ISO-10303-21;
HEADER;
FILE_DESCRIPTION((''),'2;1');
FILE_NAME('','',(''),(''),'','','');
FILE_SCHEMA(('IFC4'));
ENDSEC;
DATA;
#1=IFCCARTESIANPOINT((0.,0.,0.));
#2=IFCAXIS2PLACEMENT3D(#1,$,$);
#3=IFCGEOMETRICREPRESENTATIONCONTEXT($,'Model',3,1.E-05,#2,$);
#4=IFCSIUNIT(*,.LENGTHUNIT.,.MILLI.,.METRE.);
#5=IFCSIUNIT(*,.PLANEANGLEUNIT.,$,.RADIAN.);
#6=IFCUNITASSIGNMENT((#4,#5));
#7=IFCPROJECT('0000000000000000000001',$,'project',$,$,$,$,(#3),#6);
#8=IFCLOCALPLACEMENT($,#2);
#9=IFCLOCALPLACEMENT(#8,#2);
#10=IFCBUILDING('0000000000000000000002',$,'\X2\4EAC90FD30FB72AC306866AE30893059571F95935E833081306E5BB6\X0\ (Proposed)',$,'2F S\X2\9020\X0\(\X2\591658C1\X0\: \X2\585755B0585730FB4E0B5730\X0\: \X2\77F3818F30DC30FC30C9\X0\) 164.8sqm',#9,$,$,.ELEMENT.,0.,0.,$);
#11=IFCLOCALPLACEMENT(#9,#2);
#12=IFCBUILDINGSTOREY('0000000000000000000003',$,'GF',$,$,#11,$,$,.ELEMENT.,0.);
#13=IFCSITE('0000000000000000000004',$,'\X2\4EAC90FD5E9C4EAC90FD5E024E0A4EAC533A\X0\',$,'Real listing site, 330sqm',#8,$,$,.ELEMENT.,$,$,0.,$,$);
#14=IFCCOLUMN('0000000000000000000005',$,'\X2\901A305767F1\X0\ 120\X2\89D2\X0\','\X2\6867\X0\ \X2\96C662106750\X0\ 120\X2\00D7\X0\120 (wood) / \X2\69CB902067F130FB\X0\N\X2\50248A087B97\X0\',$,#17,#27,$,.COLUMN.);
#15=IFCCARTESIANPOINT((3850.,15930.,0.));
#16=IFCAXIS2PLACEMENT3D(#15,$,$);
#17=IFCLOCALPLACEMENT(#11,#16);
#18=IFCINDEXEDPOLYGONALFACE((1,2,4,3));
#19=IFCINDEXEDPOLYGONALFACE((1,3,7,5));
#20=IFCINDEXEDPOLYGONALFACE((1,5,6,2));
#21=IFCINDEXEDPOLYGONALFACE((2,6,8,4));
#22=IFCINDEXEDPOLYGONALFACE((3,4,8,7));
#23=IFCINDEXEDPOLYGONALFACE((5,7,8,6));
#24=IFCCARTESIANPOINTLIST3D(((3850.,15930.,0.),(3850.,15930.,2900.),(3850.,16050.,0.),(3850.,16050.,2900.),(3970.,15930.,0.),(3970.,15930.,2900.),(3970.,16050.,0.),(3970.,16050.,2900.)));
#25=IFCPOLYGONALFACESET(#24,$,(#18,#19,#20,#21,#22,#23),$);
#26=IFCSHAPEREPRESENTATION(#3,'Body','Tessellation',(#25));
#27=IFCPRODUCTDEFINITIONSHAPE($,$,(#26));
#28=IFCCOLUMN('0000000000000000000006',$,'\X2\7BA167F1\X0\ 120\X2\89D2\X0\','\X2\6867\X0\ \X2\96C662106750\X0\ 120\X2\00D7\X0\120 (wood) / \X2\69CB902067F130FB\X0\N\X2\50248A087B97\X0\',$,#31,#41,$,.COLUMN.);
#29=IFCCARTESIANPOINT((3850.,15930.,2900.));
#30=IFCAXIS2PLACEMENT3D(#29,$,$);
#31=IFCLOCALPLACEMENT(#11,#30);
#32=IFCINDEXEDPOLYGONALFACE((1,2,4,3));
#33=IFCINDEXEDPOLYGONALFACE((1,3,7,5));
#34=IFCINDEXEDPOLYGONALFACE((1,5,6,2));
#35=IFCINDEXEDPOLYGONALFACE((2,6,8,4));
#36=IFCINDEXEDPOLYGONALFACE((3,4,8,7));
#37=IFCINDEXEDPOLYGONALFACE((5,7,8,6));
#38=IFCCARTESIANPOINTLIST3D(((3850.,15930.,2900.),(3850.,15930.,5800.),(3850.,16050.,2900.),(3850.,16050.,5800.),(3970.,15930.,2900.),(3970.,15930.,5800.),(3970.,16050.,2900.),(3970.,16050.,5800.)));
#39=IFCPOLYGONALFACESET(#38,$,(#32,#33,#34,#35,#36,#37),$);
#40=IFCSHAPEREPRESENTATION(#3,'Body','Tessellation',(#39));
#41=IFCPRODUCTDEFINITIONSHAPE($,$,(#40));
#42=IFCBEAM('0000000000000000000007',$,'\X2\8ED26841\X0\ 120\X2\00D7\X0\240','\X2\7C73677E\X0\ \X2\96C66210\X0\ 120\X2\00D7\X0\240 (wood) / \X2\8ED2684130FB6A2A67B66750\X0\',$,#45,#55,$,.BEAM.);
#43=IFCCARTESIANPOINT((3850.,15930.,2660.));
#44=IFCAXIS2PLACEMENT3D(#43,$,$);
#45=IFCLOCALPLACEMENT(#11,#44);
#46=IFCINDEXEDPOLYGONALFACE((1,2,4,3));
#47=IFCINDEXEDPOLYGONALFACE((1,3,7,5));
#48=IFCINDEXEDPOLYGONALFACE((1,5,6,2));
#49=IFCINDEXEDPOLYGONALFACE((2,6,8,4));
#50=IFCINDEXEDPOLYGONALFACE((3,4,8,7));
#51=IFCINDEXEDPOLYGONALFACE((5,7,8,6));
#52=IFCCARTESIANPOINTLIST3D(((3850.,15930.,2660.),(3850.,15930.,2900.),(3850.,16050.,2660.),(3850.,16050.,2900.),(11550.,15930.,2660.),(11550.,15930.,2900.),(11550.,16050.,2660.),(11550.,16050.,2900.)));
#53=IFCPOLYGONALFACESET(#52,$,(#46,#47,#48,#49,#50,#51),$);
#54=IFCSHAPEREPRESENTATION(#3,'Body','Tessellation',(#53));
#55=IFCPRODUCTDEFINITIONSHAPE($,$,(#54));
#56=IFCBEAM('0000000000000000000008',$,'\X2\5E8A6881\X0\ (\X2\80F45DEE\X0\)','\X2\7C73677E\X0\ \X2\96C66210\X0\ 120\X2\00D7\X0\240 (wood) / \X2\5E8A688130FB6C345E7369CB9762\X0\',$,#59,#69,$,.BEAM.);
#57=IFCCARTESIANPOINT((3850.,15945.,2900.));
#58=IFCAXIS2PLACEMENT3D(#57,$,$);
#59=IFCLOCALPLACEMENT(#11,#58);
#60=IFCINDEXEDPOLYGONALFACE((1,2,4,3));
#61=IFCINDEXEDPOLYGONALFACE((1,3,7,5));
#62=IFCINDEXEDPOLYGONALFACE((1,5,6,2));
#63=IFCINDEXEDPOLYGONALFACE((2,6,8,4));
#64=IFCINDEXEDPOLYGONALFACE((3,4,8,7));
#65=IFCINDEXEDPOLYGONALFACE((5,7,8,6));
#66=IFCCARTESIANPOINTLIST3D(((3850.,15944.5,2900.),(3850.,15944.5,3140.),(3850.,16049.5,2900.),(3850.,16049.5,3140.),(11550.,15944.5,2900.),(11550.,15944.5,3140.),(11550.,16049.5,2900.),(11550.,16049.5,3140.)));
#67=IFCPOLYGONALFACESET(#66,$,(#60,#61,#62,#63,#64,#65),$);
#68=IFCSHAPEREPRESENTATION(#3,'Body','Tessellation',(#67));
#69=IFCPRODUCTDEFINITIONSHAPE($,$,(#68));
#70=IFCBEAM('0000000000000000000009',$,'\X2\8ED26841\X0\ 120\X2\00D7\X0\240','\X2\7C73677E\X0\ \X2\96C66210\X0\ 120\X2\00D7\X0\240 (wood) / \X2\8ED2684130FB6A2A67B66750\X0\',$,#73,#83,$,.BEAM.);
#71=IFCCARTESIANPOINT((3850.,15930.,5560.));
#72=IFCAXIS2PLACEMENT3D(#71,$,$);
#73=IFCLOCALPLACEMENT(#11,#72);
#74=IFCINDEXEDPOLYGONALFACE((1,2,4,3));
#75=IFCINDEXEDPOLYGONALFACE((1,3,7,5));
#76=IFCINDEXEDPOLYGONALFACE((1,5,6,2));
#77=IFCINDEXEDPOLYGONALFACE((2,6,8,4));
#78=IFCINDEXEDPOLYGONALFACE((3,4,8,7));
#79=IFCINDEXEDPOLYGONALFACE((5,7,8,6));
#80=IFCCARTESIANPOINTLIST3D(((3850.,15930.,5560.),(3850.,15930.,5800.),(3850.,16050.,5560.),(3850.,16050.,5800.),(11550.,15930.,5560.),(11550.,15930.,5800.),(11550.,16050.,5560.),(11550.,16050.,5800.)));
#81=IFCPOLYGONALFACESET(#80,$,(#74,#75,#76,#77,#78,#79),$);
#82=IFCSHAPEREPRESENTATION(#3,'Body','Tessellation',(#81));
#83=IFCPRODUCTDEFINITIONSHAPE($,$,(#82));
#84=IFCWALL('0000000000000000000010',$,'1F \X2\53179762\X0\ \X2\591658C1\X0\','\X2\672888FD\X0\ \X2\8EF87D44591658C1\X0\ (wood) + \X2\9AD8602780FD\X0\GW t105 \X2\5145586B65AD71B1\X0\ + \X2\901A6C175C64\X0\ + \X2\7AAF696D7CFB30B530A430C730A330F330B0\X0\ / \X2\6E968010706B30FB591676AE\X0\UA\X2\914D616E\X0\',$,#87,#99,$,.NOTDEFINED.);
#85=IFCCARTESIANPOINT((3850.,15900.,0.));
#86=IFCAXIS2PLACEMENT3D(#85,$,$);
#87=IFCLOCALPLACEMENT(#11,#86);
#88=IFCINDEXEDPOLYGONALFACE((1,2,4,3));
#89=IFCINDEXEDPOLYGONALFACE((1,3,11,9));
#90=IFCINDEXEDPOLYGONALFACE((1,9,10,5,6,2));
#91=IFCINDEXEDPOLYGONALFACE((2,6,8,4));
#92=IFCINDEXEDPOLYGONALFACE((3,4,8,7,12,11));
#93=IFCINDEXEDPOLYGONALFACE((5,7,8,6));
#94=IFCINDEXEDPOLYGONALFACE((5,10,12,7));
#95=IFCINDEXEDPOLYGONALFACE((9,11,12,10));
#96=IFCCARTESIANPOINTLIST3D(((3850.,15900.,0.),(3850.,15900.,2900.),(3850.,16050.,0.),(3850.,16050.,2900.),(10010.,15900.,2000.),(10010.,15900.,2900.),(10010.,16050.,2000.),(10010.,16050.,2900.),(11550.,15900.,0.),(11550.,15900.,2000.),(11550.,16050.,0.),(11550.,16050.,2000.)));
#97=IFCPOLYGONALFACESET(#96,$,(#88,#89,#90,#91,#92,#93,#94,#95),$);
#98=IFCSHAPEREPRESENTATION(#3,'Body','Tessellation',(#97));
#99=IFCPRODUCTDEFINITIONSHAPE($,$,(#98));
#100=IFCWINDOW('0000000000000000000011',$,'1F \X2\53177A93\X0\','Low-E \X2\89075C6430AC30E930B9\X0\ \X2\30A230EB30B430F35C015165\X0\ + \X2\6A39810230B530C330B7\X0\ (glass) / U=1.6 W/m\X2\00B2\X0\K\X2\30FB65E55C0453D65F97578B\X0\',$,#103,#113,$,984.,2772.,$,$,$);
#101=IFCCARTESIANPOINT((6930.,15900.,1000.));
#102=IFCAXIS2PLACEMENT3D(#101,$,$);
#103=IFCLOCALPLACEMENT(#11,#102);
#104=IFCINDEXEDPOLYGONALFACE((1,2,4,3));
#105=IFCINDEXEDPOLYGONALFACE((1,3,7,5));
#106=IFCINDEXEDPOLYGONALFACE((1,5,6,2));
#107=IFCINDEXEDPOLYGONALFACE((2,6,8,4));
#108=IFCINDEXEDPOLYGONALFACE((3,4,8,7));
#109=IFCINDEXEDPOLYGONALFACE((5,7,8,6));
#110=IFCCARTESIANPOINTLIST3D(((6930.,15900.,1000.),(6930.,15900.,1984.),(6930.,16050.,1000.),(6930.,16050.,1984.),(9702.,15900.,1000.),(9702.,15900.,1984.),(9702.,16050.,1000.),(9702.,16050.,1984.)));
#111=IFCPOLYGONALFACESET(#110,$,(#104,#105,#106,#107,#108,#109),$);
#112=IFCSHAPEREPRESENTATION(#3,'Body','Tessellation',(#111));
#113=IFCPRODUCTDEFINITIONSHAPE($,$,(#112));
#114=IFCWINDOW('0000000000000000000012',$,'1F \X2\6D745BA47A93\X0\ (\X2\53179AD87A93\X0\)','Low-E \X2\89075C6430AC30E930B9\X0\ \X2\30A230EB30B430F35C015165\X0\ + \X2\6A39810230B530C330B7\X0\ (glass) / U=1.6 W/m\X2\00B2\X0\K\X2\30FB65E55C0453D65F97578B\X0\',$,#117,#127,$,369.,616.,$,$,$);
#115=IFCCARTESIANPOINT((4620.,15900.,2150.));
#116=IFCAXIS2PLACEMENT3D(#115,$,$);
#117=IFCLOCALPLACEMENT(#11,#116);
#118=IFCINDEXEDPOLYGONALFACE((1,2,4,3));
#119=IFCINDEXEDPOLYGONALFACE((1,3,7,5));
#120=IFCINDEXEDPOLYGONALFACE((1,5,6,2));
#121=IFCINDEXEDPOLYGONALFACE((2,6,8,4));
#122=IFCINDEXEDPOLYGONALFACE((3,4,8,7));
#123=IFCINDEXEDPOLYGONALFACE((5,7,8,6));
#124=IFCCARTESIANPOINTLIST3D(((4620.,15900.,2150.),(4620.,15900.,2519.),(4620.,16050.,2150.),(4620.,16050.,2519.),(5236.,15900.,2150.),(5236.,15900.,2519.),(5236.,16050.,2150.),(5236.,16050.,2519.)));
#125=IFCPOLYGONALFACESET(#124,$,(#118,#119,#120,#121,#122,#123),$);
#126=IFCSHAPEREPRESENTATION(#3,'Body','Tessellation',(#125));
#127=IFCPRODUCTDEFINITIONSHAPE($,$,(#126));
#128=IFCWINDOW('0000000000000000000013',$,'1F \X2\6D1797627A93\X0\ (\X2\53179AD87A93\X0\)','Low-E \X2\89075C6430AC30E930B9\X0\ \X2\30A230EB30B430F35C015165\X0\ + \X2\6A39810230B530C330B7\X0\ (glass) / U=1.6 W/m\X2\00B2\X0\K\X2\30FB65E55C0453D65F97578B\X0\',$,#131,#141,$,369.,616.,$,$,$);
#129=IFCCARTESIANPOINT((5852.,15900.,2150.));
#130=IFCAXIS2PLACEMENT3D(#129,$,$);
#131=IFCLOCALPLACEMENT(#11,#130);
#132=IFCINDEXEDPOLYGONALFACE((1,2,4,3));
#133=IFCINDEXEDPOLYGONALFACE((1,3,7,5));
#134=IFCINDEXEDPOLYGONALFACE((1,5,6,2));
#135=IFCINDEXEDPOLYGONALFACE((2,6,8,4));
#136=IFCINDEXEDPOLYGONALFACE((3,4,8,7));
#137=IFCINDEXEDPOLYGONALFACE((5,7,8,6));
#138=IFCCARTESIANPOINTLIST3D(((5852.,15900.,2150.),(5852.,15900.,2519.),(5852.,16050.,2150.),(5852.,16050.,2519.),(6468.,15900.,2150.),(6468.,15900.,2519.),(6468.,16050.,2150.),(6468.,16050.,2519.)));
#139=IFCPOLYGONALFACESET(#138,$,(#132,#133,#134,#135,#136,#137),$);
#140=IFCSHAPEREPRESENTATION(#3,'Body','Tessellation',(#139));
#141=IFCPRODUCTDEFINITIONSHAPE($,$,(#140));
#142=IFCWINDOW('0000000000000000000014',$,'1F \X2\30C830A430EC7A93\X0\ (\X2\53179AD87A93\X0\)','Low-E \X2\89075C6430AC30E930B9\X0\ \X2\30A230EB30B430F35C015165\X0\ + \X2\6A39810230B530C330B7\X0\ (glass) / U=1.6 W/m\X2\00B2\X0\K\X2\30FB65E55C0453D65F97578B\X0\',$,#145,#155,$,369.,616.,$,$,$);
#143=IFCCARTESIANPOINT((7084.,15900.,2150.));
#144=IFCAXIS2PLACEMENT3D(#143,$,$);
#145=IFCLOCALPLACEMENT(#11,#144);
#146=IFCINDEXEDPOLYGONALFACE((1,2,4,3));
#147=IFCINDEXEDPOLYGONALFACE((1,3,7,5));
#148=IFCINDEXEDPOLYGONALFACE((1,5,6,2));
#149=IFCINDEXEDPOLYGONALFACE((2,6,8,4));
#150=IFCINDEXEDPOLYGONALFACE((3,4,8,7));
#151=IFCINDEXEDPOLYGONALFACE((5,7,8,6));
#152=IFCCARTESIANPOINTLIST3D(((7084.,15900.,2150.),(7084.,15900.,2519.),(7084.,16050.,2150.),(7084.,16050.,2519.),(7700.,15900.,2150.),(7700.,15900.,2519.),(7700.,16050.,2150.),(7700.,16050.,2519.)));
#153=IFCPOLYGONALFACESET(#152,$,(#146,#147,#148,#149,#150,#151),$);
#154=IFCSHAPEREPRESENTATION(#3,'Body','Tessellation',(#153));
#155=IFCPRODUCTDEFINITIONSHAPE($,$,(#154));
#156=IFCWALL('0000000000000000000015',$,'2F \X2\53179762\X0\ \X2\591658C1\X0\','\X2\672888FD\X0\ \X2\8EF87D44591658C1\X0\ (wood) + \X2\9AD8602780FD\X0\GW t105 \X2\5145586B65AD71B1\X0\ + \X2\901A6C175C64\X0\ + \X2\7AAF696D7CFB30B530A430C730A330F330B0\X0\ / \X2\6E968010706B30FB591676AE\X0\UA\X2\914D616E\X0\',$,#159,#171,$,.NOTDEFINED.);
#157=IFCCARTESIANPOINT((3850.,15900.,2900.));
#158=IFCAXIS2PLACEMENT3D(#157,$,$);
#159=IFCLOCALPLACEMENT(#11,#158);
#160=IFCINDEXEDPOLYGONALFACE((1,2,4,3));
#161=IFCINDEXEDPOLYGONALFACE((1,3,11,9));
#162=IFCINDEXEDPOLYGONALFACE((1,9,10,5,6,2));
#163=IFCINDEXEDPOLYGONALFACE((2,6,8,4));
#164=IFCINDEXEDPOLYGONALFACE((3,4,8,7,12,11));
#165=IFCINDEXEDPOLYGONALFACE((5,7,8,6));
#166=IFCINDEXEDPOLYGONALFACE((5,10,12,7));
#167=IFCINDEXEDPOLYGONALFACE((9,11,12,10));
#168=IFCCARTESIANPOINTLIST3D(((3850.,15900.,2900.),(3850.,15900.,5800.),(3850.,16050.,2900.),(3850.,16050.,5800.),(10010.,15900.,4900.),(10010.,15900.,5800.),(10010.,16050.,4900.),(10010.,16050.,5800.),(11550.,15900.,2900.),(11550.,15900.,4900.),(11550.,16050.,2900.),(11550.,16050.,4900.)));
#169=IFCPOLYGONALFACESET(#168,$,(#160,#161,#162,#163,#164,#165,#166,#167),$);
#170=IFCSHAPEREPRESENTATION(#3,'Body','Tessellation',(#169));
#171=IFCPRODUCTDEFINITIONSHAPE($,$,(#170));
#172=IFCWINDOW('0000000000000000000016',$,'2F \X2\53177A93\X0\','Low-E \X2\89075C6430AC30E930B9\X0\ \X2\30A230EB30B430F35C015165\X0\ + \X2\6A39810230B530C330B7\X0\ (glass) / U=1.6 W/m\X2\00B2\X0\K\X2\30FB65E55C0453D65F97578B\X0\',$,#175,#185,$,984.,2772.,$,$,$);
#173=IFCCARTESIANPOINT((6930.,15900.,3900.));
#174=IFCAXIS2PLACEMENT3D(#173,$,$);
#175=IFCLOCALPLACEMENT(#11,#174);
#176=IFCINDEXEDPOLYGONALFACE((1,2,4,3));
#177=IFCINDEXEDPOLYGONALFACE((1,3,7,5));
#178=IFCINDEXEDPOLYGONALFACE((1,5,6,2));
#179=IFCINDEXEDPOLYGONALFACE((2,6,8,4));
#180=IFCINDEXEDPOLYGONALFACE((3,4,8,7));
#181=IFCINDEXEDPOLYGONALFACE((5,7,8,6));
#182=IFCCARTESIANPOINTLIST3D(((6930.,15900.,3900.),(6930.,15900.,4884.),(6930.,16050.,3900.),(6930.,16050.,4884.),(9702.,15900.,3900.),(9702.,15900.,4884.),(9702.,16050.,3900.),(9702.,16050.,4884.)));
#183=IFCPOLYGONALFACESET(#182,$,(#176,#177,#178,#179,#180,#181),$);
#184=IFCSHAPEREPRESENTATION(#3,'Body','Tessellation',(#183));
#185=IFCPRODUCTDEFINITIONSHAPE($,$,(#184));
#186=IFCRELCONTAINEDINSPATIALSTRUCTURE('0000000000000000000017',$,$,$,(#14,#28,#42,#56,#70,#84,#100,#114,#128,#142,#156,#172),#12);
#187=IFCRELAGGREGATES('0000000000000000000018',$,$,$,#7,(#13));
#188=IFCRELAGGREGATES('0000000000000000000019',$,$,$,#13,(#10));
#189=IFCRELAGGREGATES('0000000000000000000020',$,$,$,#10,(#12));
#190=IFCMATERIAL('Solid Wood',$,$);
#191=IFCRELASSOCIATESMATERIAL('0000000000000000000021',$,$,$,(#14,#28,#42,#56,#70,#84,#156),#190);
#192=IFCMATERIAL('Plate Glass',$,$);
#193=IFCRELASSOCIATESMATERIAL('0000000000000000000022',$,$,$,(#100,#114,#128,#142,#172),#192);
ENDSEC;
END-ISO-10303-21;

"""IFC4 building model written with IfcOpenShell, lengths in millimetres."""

from ifc_helpers import new_model, si_unit, frame, frame_2d, origin, place, context, project, spatial, rectangle, extrude, material, element, fill, save


model = new_model("IFC4")

# Units and contexts
model_context = context("Model", 3, precision=1e-05, world=origin())
ifc_project = project(units=[si_unit("LENGTHUNIT", "METRE", prefix="MILLI"), si_unit("PLANEANGLEUNIT", "RADIAN")], contexts=[model_context])

# Site, building, storey
site_placement = place(None, origin())
site = spatial("IfcSite", under=ifc_project, at=site_placement, Name="京都府京都市上京区", ObjectType="Real listing site, 330sqm", CompositionType="ELEMENT", RefElevation=0.0)
building_placement = place(site_placement, origin())
building = spatial("IfcBuilding", under=site, at=building_placement, Name="京都・犬と暮らす土間広めの家 (Proposed)", ObjectType="2F S造(外壁: 塗喰塗・下地: 石膏ボード) 164.8sqm", CompositionType="ELEMENT", ElevationOfRefHeight=0.0, ElevationOfTerrain=0.0)
storey_placement = place(building_placement, origin())
storey = spatial("IfcBuildingStorey", under=building, at=storey_placement, Name="GF", CompositionType="ELEMENT", Elevation=0.0)

# Columns
ifc_material_1 = material(Name="Solid Wood")
column_1_placement = place(storey_placement, frame((3850.0, 15930.0, 0.0)))
element("IfcColumn", 1, at=column_1_placement, inside=storey, material=ifc_material_1, Name="通し柱 120角", Description="桧 集成材 120×120 (wood) / 構造柱・N値計算", PredefinedType="COLUMN", context=model_context, shape_type="SweptSolid", body=[
    extrude(rectangle(XDim=120.0, YDim=120.0, at=frame_2d((60.0, 60.0))), frame((3850.0, 15930.0, 0.0)), (0.0, 0.0, 1.0), 2900.0),
])
column_2_placement = place(storey_placement, frame((3850.0, 15930.0, 2900.0)))
element("IfcColumn", 2, at=column_2_placement, inside=storey, material=ifc_material_1, Name="管柱 120角", Description="桧 集成材 120×120 (wood) / 構造柱・N値計算", PredefinedType="COLUMN", context=model_context, shape_type="SweptSolid", body=[
    extrude(rectangle(XDim=120.0, YDim=120.0, at=frame_2d((60.0, 60.0))), frame((3850.0, 15930.0, 2900.0)), (0.0, 0.0, 1.0), 2900.0),
])

# Beams
beam_1_placement = place(storey_placement, frame((3850.0, 15930.0, 2660.0)))
element("IfcBeam", 3, at=beam_1_placement, inside=storey, material=ifc_material_1, Name="軒桁 120×240", Description="米松 集成 120×240 (wood) / 軒桁・横架材", PredefinedType="BEAM", context=model_context, shape_type="SweptSolid", body=[
    extrude(rectangle(XDim=7700.0, YDim=120.0, at=frame_2d((3850.0, 60.0))), frame((3850.0, 15930.0, 2660.0)), (0.0, 0.0, 1.0), 240.0),
])
beam_2_placement = place(storey_placement, frame((3850.0, 15945.0, 2900.0)))
element("IfcBeam", 4, at=beam_2_placement, inside=storey, material=ifc_material_1, Name="床梁 (胴差)", Description="米松 集成 120×240 (wood) / 床梁・水平構面", PredefinedType="BEAM", context=model_context, shape_type="SweptSolid", body=[
    extrude(rectangle(XDim=7700.0, YDim=105.0, at=frame_2d((3850.0, 52.0))), frame((3850.0, 15945.0, 2900.0)), (0.0, 0.0, 1.0), 240.0),
])
beam_3_placement = place(storey_placement, frame((3850.0, 15930.0, 5560.0)))
element("IfcBeam", 5, at=beam_3_placement, inside=storey, material=ifc_material_1, Name="軒桁 120×240", Description="米松 集成 120×240 (wood) / 軒桁・横架材", PredefinedType="BEAM", context=model_context, shape_type="SweptSolid", body=[
    extrude(rectangle(XDim=7700.0, YDim=120.0, at=frame_2d((3850.0, 60.0))), frame((3850.0, 15930.0, 5560.0)), (0.0, 0.0, 1.0), 240.0),
])

# Wall, openings, windows
wall_1_placement = place(storey_placement, frame((3850.0, 15900.0, 0.0)))
wall_1 = element("IfcWall", 6, at=wall_1_placement, inside=storey, material=ifc_material_1, Name="1F 北面 外壁", Description="木製 軸組外壁 (wood) + 高性能GW t105 充填断熱 + 通気層 + 窯業系サイディング / 準耐火・外皮UA配慮", PredefinedType="NOTDEFINED", context=model_context, shape_type="SweptSolid", body=[
    extrude(rectangle(XDim=7700.0, YDim=150.0, at=frame_2d((3850.0, 75.0))), frame((3850.0, 15900.0, 0.0)), (0.0, 0.0, 1.0), 2900.0),
])
opening_1_placement = place(storey_placement, frame((6930.0, 15900.0, 1000.0)))
opening_1 = element("IfcOpeningElement", 7, at=opening_1_placement, cuts=wall_1, PredefinedType="NOTDEFINED", context=model_context, shape_type="SweptSolid", body=[
    extrude(rectangle(XDim=2772.0, YDim=150.0, at=frame_2d((1386.0, 75.0))), frame((6930.0, 15900.0, 1000.0)), (0.0, 0.0, 1.0), 984.0),
])
opening_2_placement = place(storey_placement, frame((4620.0, 15900.0, 2150.0)))
opening_2 = element("IfcOpeningElement", 8, at=opening_2_placement, cuts=wall_1, PredefinedType="NOTDEFINED", context=model_context, shape_type="SweptSolid", body=[
    extrude(rectangle(XDim=616.0, YDim=150.0, at=frame_2d((308.0, 75.0))), frame((4620.0, 15900.0, 2150.0)), (0.0, 0.0, 1.0), 369.0),
])
opening_3_placement = place(storey_placement, frame((5852.0, 15900.0, 2150.0)))
opening_3 = element("IfcOpeningElement", 9, at=opening_3_placement, cuts=wall_1, PredefinedType="NOTDEFINED", context=model_context, shape_type="SweptSolid", body=[
    extrude(rectangle(XDim=616.0, YDim=150.0, at=frame_2d((308.0, 75.0))), frame((5852.0, 15900.0, 2150.0)), (0.0, 0.0, 1.0), 369.0),
])
opening_4_placement = place(storey_placement, frame((7084.0, 15900.0, 2150.0)))
opening_4 = element("IfcOpeningElement", 10, at=opening_4_placement, cuts=wall_1, PredefinedType="NOTDEFINED", context=model_context, shape_type="SweptSolid", body=[
    extrude(rectangle(XDim=616.0, YDim=150.0, at=frame_2d((308.0, 75.0))), frame((7084.0, 15900.0, 2150.0)), (0.0, 0.0, 1.0), 369.0),
])
ifc_material_2 = material(Name="Plate Glass")
window_1_placement = place(storey_placement, frame((6930.0, 15900.0, 1000.0)))
window_1 = element("IfcWindow", 11, at=window_1_placement, inside=storey, material=ifc_material_2, Name="1F 北窓", Description="Low-E 複層ガラス アルゴン封入 + 樹脂サッシ (glass) / U=1.6 W/m²K・日射取得型", OverallHeight=984.0, OverallWidth=2772.0, context=model_context, shape_type="SweptSolid", body=[
    extrude(rectangle(XDim=2772.0, YDim=150.0, at=frame_2d((1386.0, 75.0))), frame((6930.0, 15900.0, 1000.0)), (0.0, 0.0, 1.0), 984.0),
])
fill(opening_1, window_1)
window_2_placement = place(storey_placement, frame((4620.0, 15900.0, 2150.0)))
window_2 = element("IfcWindow", 12, at=window_2_placement, inside=storey, material=ifc_material_2, Name="1F 浴室窓 (北高窓)", Description="Low-E 複層ガラス アルゴン封入 + 樹脂サッシ (glass) / U=1.6 W/m²K・日射取得型", OverallHeight=369.0, OverallWidth=616.0, context=model_context, shape_type="SweptSolid", body=[
    extrude(rectangle(XDim=616.0, YDim=150.0, at=frame_2d((308.0, 75.0))), frame((4620.0, 15900.0, 2150.0)), (0.0, 0.0, 1.0), 369.0),
])
fill(opening_2, window_2)
window_3_placement = place(storey_placement, frame((5852.0, 15900.0, 2150.0)))
window_3 = element("IfcWindow", 13, at=window_3_placement, inside=storey, material=ifc_material_2, Name="1F 洗面窓 (北高窓)", Description="Low-E 複層ガラス アルゴン封入 + 樹脂サッシ (glass) / U=1.6 W/m²K・日射取得型", OverallHeight=369.0, OverallWidth=616.0, context=model_context, shape_type="SweptSolid", body=[
    extrude(rectangle(XDim=616.0, YDim=150.0, at=frame_2d((308.0, 75.0))), frame((5852.0, 15900.0, 2150.0)), (0.0, 0.0, 1.0), 369.0),
])
fill(opening_3, window_3)
window_4_placement = place(storey_placement, frame((7084.0, 15900.0, 2150.0)))
window_4 = element("IfcWindow", 14, at=window_4_placement, inside=storey, material=ifc_material_2, Name="1F トイレ窓 (北高窓)", Description="Low-E 複層ガラス アルゴン封入 + 樹脂サッシ (glass) / U=1.6 W/m²K・日射取得型", OverallHeight=369.0, OverallWidth=616.0, context=model_context, shape_type="SweptSolid", body=[
    extrude(rectangle(XDim=616.0, YDim=150.0, at=frame_2d((308.0, 75.0))), frame((7084.0, 15900.0, 2150.0)), (0.0, 0.0, 1.0), 369.0),
])
fill(opening_4, window_4)

# Wall, opening, window
wall_2_placement = place(storey_placement, frame((3850.0, 15900.0, 2900.0)))
wall_2 = element("IfcWall", 15, at=wall_2_placement, inside=storey, material=ifc_material_1, Name="2F 北面 外壁", Description="木製 軸組外壁 (wood) + 高性能GW t105 充填断熱 + 通気層 + 窯業系サイディング / 準耐火・外皮UA配慮", PredefinedType="NOTDEFINED", context=model_context, shape_type="SweptSolid", body=[
    extrude(rectangle(XDim=7700.0, YDim=150.0, at=frame_2d((3850.0, 75.0))), frame((3850.0, 15900.0, 2900.0)), (0.0, 0.0, 1.0), 2900.0),
])
opening_5_placement = place(storey_placement, frame((6930.0, 15900.0, 3900.0)))
opening_5 = element("IfcOpeningElement", 16, at=opening_5_placement, cuts=wall_2, PredefinedType="NOTDEFINED", context=model_context, shape_type="SweptSolid", body=[
    extrude(rectangle(XDim=2772.0, YDim=150.0, at=frame_2d((1386.0, 75.0))), frame((6930.0, 15900.0, 3900.0)), (0.0, 0.0, 1.0), 984.0),
])
window_5_placement = place(storey_placement, frame((6930.0, 15900.0, 3900.0)))
window_5 = element("IfcWindow", 17, at=window_5_placement, inside=storey, material=ifc_material_2, Name="2F 北窓", Description="Low-E 複層ガラス アルゴン封入 + 樹脂サッシ (glass) / U=1.6 W/m²K・日射取得型", OverallHeight=984.0, OverallWidth=2772.0, context=model_context, shape_type="SweptSolid", body=[
    extrude(rectangle(XDim=2772.0, YDim=150.0, at=frame_2d((1386.0, 75.0))), frame((6930.0, 15900.0, 3900.0)), (0.0, 0.0, 1.0), 984.0),
])
fill(opening_5, window_5)

save(model, "model.ifc")
